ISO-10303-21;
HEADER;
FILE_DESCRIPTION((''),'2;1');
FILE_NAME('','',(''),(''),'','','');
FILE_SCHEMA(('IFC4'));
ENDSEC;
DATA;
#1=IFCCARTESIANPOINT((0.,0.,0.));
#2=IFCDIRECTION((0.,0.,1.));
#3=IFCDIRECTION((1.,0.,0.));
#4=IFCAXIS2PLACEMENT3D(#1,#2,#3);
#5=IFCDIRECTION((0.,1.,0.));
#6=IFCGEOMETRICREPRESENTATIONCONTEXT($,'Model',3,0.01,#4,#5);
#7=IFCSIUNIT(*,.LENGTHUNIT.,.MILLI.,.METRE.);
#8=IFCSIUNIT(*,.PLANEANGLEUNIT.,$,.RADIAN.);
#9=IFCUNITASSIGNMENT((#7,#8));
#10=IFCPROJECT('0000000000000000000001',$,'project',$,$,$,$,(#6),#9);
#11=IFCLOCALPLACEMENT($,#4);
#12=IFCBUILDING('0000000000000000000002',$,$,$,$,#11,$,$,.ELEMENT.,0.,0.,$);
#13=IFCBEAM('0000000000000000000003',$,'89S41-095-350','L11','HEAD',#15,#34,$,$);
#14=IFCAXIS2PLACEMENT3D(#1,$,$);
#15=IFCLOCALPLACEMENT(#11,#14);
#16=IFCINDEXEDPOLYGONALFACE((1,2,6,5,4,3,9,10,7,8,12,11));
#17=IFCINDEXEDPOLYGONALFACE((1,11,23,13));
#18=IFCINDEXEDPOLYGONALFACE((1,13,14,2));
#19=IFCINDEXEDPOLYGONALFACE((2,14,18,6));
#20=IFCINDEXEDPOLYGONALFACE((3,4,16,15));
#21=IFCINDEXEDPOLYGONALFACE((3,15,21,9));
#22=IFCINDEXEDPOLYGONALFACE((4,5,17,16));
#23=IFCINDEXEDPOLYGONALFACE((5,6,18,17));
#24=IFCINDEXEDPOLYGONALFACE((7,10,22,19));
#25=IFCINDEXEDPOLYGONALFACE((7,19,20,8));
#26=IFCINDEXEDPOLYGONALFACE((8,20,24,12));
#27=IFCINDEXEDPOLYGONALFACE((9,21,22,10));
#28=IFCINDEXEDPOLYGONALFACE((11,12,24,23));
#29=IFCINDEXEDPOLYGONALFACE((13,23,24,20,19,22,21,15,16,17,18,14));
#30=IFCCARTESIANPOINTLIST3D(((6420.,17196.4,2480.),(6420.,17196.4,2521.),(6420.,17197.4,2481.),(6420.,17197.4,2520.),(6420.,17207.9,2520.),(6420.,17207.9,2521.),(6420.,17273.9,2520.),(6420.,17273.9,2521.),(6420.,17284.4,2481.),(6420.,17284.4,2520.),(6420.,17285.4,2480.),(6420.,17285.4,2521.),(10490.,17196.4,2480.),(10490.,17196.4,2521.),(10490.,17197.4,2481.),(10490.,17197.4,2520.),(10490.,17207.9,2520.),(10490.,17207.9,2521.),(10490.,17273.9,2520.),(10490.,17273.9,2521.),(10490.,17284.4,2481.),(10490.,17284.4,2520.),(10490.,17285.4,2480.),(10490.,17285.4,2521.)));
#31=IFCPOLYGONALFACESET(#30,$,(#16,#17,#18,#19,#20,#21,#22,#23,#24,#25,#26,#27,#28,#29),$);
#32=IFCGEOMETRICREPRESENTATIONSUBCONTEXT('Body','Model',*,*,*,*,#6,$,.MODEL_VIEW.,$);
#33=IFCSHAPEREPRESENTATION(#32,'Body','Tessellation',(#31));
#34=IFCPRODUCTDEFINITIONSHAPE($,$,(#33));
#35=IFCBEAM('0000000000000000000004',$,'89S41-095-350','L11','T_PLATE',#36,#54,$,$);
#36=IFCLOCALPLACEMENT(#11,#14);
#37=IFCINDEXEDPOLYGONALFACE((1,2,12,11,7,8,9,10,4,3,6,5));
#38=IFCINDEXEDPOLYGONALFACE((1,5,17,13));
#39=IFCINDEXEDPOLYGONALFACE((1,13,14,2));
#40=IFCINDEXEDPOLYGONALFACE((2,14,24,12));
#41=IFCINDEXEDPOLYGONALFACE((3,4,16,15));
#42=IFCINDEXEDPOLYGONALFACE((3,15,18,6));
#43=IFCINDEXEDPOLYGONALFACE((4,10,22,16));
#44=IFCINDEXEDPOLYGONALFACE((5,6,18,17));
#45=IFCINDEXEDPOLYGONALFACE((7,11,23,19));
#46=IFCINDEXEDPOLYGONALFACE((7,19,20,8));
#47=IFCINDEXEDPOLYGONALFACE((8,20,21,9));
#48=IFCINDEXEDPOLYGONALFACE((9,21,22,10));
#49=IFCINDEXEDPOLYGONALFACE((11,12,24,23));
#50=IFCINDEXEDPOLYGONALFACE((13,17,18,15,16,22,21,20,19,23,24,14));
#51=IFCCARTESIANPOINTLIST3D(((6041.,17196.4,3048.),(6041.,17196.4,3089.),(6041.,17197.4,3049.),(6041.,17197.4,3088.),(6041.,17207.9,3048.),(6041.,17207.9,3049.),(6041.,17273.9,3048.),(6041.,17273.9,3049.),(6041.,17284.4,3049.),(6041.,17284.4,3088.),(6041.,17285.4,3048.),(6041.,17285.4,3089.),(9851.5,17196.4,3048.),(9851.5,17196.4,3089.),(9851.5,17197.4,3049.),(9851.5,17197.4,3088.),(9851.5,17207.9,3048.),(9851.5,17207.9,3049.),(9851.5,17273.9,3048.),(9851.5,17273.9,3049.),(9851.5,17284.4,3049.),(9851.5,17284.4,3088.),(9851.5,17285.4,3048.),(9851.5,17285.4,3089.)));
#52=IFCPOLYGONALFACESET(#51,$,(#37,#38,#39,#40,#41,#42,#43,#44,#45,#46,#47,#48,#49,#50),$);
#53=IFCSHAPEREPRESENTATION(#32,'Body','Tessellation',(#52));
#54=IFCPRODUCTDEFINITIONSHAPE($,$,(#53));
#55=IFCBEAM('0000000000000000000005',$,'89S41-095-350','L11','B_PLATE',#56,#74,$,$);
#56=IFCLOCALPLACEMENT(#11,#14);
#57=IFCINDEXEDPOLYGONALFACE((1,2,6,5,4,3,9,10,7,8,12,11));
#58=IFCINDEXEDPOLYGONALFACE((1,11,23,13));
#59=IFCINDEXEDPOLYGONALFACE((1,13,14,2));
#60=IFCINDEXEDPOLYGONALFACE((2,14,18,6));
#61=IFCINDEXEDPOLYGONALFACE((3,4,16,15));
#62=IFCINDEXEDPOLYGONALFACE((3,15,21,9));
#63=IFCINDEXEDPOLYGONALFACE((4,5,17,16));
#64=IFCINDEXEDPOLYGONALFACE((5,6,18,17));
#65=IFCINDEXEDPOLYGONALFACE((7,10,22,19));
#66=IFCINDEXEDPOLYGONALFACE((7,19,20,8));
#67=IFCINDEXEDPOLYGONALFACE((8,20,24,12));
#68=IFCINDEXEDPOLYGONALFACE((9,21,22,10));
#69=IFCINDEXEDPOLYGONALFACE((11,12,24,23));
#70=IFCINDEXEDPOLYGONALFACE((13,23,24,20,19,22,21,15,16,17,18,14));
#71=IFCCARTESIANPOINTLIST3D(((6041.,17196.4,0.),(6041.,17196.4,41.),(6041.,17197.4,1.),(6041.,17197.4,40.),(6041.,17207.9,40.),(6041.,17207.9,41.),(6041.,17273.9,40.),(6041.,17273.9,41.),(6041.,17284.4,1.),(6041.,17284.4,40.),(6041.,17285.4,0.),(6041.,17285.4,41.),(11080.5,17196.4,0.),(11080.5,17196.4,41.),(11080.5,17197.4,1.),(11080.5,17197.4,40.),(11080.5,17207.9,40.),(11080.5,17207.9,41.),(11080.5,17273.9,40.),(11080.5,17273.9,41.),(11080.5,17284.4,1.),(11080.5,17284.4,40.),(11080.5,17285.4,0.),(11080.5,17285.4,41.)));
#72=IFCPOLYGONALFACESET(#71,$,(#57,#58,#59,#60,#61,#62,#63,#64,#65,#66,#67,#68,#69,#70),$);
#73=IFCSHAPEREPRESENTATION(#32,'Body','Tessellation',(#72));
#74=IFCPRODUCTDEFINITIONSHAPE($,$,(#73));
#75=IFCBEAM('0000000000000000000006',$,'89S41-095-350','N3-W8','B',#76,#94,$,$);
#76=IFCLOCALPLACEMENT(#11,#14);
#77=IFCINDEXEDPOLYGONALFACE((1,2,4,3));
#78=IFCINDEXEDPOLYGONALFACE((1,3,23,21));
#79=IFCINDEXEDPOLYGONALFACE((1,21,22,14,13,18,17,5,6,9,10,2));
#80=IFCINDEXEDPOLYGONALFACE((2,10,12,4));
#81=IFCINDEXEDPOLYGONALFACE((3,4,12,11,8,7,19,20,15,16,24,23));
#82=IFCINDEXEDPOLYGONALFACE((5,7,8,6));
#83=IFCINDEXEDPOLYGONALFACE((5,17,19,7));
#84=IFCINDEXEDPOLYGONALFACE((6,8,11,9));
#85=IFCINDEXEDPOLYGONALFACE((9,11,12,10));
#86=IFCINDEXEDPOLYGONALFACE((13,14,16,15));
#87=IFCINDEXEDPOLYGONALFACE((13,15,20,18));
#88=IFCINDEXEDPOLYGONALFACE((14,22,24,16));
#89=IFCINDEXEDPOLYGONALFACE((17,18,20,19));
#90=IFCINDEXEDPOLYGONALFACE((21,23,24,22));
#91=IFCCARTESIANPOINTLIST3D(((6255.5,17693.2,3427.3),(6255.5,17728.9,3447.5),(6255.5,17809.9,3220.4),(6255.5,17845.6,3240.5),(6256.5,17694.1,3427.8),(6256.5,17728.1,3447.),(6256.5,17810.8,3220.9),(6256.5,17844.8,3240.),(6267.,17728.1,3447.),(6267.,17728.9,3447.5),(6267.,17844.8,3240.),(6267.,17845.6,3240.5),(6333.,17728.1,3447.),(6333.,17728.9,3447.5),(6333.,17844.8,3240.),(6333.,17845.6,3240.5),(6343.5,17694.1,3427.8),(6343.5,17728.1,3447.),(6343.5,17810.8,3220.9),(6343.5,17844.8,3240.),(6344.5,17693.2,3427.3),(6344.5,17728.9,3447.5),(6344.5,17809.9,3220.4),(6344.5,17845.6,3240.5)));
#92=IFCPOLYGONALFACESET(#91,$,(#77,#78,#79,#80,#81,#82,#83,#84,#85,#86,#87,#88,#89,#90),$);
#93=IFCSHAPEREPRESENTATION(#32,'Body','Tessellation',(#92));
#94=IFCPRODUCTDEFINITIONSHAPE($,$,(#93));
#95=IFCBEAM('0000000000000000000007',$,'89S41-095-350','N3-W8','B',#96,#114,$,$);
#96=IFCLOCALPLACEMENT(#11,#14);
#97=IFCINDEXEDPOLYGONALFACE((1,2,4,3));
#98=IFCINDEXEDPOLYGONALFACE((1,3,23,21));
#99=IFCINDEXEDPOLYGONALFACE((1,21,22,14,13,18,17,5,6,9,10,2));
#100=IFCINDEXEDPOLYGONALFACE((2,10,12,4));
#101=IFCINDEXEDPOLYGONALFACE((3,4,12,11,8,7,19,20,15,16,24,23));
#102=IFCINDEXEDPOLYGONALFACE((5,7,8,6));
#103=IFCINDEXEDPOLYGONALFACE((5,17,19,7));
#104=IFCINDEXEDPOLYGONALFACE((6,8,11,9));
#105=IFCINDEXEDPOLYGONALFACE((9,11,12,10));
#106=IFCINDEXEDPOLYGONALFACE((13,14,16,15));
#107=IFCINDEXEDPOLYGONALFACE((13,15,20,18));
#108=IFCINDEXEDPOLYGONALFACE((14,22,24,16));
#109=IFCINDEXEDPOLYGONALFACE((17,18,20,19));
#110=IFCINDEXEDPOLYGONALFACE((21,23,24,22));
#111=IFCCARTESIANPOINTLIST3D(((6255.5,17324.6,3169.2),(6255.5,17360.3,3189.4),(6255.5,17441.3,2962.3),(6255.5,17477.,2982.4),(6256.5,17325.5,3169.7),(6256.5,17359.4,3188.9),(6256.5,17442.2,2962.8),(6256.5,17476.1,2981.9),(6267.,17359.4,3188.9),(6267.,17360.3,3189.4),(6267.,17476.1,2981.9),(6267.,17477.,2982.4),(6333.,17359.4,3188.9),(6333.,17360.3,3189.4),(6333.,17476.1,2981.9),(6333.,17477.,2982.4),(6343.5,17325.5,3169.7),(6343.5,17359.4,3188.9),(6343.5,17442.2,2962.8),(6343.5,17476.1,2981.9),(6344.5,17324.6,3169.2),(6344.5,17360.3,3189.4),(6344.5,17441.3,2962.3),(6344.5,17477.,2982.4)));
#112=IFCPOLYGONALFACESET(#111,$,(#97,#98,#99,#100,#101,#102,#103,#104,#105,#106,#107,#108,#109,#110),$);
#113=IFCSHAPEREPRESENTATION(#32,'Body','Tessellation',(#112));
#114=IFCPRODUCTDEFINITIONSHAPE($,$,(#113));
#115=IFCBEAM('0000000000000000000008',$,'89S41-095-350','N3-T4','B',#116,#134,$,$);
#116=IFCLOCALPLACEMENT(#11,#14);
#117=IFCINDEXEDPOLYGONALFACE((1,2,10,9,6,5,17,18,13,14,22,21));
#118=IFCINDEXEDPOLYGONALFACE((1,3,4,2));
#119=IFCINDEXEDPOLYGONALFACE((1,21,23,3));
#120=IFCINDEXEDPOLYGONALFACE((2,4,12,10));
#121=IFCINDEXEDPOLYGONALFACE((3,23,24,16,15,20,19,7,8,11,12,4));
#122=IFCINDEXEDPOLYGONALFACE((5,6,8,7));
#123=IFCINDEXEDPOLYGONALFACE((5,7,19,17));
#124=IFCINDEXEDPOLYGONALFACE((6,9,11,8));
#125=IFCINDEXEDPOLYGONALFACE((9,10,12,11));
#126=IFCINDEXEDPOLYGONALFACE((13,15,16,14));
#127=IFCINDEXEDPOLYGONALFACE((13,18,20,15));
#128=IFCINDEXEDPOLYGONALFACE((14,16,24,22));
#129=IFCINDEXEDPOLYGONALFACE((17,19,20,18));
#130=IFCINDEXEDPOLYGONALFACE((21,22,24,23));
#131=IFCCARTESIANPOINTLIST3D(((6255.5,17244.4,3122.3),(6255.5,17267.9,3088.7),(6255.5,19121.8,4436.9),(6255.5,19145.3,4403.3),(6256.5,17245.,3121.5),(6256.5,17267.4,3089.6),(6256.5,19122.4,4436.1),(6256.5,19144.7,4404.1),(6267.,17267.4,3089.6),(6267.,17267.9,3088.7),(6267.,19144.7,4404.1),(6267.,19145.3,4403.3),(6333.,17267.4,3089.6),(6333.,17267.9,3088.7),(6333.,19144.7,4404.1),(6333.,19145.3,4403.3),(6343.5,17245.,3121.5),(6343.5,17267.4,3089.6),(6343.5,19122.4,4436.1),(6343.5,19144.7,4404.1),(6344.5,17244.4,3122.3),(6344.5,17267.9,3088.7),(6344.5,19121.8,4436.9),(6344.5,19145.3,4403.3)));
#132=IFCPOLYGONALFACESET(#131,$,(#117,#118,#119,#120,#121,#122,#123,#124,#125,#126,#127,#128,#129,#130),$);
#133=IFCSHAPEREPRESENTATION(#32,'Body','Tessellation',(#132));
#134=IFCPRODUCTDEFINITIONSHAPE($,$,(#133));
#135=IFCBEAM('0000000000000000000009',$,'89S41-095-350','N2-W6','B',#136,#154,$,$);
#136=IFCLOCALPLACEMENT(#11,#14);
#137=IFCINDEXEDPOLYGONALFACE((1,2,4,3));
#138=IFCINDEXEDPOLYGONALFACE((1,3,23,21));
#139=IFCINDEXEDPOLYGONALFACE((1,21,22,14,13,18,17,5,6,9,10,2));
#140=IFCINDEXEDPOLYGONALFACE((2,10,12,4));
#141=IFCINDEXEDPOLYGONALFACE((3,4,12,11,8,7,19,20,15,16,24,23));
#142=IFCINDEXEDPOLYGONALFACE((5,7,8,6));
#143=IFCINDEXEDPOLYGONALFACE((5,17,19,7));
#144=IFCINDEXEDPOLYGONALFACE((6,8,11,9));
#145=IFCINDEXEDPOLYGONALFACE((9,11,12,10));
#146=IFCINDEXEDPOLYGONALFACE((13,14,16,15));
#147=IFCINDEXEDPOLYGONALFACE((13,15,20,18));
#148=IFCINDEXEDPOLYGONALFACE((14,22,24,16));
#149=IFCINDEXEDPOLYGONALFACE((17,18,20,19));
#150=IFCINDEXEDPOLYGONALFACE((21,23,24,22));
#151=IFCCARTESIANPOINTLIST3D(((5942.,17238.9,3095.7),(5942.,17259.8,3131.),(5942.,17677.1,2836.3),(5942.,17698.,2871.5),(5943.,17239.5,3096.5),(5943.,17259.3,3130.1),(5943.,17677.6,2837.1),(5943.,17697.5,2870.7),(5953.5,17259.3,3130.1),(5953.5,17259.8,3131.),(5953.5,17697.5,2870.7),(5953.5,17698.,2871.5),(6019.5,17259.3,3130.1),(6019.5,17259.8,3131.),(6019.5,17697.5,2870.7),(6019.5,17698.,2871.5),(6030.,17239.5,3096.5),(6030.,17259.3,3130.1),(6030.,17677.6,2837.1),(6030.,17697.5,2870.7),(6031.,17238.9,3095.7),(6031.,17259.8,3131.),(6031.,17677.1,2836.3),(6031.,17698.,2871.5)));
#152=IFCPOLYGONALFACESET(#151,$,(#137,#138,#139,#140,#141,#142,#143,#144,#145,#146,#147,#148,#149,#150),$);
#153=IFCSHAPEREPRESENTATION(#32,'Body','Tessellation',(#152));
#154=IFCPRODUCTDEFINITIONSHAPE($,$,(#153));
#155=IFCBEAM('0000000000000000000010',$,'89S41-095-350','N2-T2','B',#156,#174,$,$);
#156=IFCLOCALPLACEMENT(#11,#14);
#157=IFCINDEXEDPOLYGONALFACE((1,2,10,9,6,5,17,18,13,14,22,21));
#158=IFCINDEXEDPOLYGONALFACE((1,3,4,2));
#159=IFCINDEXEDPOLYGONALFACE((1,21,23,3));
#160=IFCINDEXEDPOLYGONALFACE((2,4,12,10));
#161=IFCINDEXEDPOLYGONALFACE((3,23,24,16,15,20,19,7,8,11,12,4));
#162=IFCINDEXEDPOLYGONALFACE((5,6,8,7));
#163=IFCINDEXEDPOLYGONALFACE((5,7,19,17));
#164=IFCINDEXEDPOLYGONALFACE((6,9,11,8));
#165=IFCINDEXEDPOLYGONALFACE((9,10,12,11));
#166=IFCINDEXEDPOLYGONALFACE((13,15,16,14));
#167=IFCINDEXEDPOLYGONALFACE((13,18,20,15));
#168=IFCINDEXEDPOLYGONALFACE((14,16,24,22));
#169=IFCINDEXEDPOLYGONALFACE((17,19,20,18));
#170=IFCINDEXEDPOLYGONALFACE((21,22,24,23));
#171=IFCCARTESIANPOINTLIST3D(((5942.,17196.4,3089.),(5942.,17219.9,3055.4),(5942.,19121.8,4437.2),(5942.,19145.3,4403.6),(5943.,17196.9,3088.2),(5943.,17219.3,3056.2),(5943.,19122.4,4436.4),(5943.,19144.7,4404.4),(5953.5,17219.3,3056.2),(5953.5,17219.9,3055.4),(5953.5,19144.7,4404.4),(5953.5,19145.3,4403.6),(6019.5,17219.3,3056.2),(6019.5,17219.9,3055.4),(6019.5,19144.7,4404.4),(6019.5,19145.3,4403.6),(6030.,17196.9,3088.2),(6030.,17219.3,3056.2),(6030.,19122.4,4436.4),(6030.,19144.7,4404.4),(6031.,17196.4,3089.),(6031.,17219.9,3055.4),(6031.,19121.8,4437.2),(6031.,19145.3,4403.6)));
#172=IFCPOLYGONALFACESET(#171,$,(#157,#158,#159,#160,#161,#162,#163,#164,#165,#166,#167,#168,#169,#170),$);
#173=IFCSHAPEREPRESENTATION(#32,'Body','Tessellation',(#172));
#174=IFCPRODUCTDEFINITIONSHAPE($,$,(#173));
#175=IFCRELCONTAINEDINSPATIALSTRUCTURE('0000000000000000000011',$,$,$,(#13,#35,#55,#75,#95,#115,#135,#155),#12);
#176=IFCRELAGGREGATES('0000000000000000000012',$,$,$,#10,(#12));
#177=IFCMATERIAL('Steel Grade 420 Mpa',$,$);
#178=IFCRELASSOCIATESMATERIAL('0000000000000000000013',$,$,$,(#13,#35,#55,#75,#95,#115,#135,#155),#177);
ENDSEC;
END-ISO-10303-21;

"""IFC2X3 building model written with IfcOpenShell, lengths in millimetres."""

from ifc_helpers import new_model, si_unit, direction, frame, origin, origin_with_axes, origin_2d_with_axis, place, context, subcontext, project, spatial, c_section, extrude, source, transform, mapped, material, element, save


model = new_model("IFC2X3")

# Units and contexts
model_context = context("Model", 3, precision=0.01, world=origin_with_axes(), true_north=direction((0.0, 1.0, 0.0)))
body_context = subcontext(model_context, "Body", "Model", "MODEL_VIEW")
ifc_project = project(units=[si_unit("LENGTHUNIT", "METRE", prefix="MILLI"), si_unit("PLANEANGLEUNIT", "RADIAN")], contexts=[model_context])

# Building
building_placement = place(None, origin_with_axes())
building = spatial("IfcBuilding", under=ifc_project, at=building_placement, CompositionType="ELEMENT", ElevationOfRefHeight=0.0, ElevationOfTerrain=0.0)

# Shared definitions
ifc_material = material(Name="Steel Grade 420 Mpa")

# Beams
shared_shape_1 = source(origin(), body_context, "Body", "SweptSolid", [
    extrude(c_section(Depth=89.0, Width=41.0, WallThickness=1.0, Girth=11.5, at=origin_2d_with_axis()), origin_with_axes(), (0.0, 0.0, 1.0), 4070.0),
])
beam_1_placement = place(None, frame((6420.0, 17240.9, 2500.5), z_axis=(1.0, 0.0, 0.0), x_axis=(0.0, 0.0, 1.0)))
element("IfcBeam", 1, at=beam_1_placement, inside=building, material=ifc_material, Name="89S41-095-350", Description="L11", ObjectType="HEAD", context=body_context, shape_type="MappedRepresentation", body=[
    mapped(shared_shape_1, transform((0.0, 0.0, 0.0), scale=1.0)),
])
shared_shape_2 = source(origin(), body_context, "Body", "SweptSolid", [
    extrude(c_section(Depth=89.0, Width=41.0, WallThickness=1.0, Girth=11.5, at=origin_2d_with_axis()), origin_with_axes(), (0.0, 0.0, 1.0), 3810.5),
])
beam_2_placement = place(None, frame((6041.0, 17240.9, 3068.5), z_axis=(1.0, 0.0, 0.0), x_axis=(0.0, 0.0, -1.0)))
element("IfcBeam", 2, at=beam_2_placement, inside=building, material=ifc_material, Name="89S41-095-350", Description="L11", ObjectType="T_PLATE", context=body_context, shape_type="MappedRepresentation", body=[
    mapped(shared_shape_2, transform((0.0, 0.0, 0.0), scale=1.0)),
])
shared_shape_3 = source(origin(), body_context, "Body", "SweptSolid", [
    extrude(c_section(Depth=89.0, Width=41.0, WallThickness=1.0, Girth=11.5, at=origin_2d_with_axis()), origin_with_axes(), (0.0, 0.0, 1.0), 5039.5),
])
beam_3_placement = place(None, frame((6041.0, 17240.9, 20.5), z_axis=(1.0, 0.0, 0.0), x_axis=(0.0, 0.0, 1.0)))
element("IfcBeam", 3, at=beam_3_placement, inside=building, material=ifc_material, Name="89S41-095-350", Description="L11", ObjectType="B_PLATE", context=body_context, shape_type="MappedRepresentation", body=[
    mapped(shared_shape_3, transform((0.0, 0.0, 0.0), scale=1.0)),
])
shared_shape_4 = source(origin(), body_context, "Body", "SweptSolid", [
    extrude(c_section(Depth=89.0, Width=41.0, WallThickness=1.0, Girth=11.5, at=origin_2d_with_axis()), origin_with_axes(), (0.0, 0.0, 1.0), 237.6),
])
beam_4_placement = place(None, frame((6300.0, 17827.8, 3230.5), z_axis=(0.0, -0.491169, 0.871064), x_axis=(0.0, 0.871064, 0.491169)))
element("IfcBeam", 4, at=beam_4_placement, inside=building, material=ifc_material, Name="89S41-095-350", Description="N3-W8", ObjectType="B", context=body_context, shape_type="MappedRepresentation", body=[
    mapped(shared_shape_4, transform((0.0, 0.0, 0.0), scale=1.0)),
])
shared_shape_5 = source(origin(), body_context, "Body", "SweptSolid", [
    extrude(c_section(Depth=89.0, Width=41.0, WallThickness=1.0, Girth=11.5, at=origin_2d_with_axis()), origin_with_axes(), (0.0, 0.0, 1.0), 237.6),
])
beam_5_placement = place(None, frame((6300.0, 17459.2, 2972.3), z_axis=(0.0, -0.491169, 0.871064), x_axis=(0.0, 0.871064, 0.491169)))
element("IfcBeam", 5, at=beam_5_placement, inside=building, material=ifc_material, Name="89S41-095-350", Description="N3-W8", ObjectType="B", context=body_context, shape_type="MappedRepresentation", body=[
    mapped(shared_shape_5, transform((0.0, 0.0, 0.0), scale=1.0)),
])
shared_shape_6 = source(origin(), body_context, "Body", "SweptSolid", [
    extrude(c_section(Depth=89.0, Width=41.0, WallThickness=1.0, Girth=11.5, at=origin_2d_with_axis()), origin_with_axes(), (0.0, 0.0, 1.0), 2291.9),
])
beam_6_placement = place(None, frame((6300.0, 17256.2, 3105.5), z_axis=(0.0, 0.819152, 0.573576), x_axis=(0.0, 0.573576, -0.819152)))
element("IfcBeam", 6, at=beam_6_placement, inside=building, material=ifc_material, Name="89S41-095-350", Description="N3-T4", ObjectType="B", context=body_context, shape_type="MappedRepresentation", body=[
    mapped(shared_shape_6, transform((0.0, 0.0, 0.0), scale=1.0)),
])
shared_shape_7 = source(origin(), body_context, "Body", "SweptSolid", [
    extrude(c_section(Depth=89.0, Width=41.0, WallThickness=1.0, Girth=11.5, at=origin_2d_with_axis()), origin_with_axes(), (0.0, 0.0, 1.0), 509.2),
])
beam_7_placement = place(None, frame((5986.5, 17687.6, 2853.9), z_axis=(0.0, -0.860497, 0.509455), x_axis=(0.0, 0.509455, 0.860497)))
element("IfcBeam", 7, at=beam_7_placement, inside=building, material=ifc_material, Name="89S41-095-350", Description="N2-W6", ObjectType="B", context=body_context, shape_type="MappedRepresentation", body=[
    mapped(shared_shape_7, transform((0.0, 0.0, 0.0), scale=1.0)),
])
shared_shape_8 = source(origin(), body_context, "Body", "SweptSolid", [
    extrude(c_section(Depth=89.0, Width=41.0, WallThickness=1.0, Girth=11.5, at=origin_2d_with_axis()), origin_with_axes(), (0.0, 0.0, 1.0), 2350.5),
])
beam_8_placement = place(None, frame((5986.5, 17208.1, 3072.2), z_axis=(0.0, 0.819152, 0.573576), x_axis=(0.0, 0.573576, -0.819152)))
element("IfcBeam", 8, at=beam_8_placement, inside=building, material=ifc_material, Name="89S41-095-350", Description="N2-T2", ObjectType="B", context=body_context, shape_type="MappedRepresentation", body=[
    mapped(shared_shape_8, transform((0.0, 0.0, 0.0), scale=1.0)),
])

save(model, "model.ifc")
